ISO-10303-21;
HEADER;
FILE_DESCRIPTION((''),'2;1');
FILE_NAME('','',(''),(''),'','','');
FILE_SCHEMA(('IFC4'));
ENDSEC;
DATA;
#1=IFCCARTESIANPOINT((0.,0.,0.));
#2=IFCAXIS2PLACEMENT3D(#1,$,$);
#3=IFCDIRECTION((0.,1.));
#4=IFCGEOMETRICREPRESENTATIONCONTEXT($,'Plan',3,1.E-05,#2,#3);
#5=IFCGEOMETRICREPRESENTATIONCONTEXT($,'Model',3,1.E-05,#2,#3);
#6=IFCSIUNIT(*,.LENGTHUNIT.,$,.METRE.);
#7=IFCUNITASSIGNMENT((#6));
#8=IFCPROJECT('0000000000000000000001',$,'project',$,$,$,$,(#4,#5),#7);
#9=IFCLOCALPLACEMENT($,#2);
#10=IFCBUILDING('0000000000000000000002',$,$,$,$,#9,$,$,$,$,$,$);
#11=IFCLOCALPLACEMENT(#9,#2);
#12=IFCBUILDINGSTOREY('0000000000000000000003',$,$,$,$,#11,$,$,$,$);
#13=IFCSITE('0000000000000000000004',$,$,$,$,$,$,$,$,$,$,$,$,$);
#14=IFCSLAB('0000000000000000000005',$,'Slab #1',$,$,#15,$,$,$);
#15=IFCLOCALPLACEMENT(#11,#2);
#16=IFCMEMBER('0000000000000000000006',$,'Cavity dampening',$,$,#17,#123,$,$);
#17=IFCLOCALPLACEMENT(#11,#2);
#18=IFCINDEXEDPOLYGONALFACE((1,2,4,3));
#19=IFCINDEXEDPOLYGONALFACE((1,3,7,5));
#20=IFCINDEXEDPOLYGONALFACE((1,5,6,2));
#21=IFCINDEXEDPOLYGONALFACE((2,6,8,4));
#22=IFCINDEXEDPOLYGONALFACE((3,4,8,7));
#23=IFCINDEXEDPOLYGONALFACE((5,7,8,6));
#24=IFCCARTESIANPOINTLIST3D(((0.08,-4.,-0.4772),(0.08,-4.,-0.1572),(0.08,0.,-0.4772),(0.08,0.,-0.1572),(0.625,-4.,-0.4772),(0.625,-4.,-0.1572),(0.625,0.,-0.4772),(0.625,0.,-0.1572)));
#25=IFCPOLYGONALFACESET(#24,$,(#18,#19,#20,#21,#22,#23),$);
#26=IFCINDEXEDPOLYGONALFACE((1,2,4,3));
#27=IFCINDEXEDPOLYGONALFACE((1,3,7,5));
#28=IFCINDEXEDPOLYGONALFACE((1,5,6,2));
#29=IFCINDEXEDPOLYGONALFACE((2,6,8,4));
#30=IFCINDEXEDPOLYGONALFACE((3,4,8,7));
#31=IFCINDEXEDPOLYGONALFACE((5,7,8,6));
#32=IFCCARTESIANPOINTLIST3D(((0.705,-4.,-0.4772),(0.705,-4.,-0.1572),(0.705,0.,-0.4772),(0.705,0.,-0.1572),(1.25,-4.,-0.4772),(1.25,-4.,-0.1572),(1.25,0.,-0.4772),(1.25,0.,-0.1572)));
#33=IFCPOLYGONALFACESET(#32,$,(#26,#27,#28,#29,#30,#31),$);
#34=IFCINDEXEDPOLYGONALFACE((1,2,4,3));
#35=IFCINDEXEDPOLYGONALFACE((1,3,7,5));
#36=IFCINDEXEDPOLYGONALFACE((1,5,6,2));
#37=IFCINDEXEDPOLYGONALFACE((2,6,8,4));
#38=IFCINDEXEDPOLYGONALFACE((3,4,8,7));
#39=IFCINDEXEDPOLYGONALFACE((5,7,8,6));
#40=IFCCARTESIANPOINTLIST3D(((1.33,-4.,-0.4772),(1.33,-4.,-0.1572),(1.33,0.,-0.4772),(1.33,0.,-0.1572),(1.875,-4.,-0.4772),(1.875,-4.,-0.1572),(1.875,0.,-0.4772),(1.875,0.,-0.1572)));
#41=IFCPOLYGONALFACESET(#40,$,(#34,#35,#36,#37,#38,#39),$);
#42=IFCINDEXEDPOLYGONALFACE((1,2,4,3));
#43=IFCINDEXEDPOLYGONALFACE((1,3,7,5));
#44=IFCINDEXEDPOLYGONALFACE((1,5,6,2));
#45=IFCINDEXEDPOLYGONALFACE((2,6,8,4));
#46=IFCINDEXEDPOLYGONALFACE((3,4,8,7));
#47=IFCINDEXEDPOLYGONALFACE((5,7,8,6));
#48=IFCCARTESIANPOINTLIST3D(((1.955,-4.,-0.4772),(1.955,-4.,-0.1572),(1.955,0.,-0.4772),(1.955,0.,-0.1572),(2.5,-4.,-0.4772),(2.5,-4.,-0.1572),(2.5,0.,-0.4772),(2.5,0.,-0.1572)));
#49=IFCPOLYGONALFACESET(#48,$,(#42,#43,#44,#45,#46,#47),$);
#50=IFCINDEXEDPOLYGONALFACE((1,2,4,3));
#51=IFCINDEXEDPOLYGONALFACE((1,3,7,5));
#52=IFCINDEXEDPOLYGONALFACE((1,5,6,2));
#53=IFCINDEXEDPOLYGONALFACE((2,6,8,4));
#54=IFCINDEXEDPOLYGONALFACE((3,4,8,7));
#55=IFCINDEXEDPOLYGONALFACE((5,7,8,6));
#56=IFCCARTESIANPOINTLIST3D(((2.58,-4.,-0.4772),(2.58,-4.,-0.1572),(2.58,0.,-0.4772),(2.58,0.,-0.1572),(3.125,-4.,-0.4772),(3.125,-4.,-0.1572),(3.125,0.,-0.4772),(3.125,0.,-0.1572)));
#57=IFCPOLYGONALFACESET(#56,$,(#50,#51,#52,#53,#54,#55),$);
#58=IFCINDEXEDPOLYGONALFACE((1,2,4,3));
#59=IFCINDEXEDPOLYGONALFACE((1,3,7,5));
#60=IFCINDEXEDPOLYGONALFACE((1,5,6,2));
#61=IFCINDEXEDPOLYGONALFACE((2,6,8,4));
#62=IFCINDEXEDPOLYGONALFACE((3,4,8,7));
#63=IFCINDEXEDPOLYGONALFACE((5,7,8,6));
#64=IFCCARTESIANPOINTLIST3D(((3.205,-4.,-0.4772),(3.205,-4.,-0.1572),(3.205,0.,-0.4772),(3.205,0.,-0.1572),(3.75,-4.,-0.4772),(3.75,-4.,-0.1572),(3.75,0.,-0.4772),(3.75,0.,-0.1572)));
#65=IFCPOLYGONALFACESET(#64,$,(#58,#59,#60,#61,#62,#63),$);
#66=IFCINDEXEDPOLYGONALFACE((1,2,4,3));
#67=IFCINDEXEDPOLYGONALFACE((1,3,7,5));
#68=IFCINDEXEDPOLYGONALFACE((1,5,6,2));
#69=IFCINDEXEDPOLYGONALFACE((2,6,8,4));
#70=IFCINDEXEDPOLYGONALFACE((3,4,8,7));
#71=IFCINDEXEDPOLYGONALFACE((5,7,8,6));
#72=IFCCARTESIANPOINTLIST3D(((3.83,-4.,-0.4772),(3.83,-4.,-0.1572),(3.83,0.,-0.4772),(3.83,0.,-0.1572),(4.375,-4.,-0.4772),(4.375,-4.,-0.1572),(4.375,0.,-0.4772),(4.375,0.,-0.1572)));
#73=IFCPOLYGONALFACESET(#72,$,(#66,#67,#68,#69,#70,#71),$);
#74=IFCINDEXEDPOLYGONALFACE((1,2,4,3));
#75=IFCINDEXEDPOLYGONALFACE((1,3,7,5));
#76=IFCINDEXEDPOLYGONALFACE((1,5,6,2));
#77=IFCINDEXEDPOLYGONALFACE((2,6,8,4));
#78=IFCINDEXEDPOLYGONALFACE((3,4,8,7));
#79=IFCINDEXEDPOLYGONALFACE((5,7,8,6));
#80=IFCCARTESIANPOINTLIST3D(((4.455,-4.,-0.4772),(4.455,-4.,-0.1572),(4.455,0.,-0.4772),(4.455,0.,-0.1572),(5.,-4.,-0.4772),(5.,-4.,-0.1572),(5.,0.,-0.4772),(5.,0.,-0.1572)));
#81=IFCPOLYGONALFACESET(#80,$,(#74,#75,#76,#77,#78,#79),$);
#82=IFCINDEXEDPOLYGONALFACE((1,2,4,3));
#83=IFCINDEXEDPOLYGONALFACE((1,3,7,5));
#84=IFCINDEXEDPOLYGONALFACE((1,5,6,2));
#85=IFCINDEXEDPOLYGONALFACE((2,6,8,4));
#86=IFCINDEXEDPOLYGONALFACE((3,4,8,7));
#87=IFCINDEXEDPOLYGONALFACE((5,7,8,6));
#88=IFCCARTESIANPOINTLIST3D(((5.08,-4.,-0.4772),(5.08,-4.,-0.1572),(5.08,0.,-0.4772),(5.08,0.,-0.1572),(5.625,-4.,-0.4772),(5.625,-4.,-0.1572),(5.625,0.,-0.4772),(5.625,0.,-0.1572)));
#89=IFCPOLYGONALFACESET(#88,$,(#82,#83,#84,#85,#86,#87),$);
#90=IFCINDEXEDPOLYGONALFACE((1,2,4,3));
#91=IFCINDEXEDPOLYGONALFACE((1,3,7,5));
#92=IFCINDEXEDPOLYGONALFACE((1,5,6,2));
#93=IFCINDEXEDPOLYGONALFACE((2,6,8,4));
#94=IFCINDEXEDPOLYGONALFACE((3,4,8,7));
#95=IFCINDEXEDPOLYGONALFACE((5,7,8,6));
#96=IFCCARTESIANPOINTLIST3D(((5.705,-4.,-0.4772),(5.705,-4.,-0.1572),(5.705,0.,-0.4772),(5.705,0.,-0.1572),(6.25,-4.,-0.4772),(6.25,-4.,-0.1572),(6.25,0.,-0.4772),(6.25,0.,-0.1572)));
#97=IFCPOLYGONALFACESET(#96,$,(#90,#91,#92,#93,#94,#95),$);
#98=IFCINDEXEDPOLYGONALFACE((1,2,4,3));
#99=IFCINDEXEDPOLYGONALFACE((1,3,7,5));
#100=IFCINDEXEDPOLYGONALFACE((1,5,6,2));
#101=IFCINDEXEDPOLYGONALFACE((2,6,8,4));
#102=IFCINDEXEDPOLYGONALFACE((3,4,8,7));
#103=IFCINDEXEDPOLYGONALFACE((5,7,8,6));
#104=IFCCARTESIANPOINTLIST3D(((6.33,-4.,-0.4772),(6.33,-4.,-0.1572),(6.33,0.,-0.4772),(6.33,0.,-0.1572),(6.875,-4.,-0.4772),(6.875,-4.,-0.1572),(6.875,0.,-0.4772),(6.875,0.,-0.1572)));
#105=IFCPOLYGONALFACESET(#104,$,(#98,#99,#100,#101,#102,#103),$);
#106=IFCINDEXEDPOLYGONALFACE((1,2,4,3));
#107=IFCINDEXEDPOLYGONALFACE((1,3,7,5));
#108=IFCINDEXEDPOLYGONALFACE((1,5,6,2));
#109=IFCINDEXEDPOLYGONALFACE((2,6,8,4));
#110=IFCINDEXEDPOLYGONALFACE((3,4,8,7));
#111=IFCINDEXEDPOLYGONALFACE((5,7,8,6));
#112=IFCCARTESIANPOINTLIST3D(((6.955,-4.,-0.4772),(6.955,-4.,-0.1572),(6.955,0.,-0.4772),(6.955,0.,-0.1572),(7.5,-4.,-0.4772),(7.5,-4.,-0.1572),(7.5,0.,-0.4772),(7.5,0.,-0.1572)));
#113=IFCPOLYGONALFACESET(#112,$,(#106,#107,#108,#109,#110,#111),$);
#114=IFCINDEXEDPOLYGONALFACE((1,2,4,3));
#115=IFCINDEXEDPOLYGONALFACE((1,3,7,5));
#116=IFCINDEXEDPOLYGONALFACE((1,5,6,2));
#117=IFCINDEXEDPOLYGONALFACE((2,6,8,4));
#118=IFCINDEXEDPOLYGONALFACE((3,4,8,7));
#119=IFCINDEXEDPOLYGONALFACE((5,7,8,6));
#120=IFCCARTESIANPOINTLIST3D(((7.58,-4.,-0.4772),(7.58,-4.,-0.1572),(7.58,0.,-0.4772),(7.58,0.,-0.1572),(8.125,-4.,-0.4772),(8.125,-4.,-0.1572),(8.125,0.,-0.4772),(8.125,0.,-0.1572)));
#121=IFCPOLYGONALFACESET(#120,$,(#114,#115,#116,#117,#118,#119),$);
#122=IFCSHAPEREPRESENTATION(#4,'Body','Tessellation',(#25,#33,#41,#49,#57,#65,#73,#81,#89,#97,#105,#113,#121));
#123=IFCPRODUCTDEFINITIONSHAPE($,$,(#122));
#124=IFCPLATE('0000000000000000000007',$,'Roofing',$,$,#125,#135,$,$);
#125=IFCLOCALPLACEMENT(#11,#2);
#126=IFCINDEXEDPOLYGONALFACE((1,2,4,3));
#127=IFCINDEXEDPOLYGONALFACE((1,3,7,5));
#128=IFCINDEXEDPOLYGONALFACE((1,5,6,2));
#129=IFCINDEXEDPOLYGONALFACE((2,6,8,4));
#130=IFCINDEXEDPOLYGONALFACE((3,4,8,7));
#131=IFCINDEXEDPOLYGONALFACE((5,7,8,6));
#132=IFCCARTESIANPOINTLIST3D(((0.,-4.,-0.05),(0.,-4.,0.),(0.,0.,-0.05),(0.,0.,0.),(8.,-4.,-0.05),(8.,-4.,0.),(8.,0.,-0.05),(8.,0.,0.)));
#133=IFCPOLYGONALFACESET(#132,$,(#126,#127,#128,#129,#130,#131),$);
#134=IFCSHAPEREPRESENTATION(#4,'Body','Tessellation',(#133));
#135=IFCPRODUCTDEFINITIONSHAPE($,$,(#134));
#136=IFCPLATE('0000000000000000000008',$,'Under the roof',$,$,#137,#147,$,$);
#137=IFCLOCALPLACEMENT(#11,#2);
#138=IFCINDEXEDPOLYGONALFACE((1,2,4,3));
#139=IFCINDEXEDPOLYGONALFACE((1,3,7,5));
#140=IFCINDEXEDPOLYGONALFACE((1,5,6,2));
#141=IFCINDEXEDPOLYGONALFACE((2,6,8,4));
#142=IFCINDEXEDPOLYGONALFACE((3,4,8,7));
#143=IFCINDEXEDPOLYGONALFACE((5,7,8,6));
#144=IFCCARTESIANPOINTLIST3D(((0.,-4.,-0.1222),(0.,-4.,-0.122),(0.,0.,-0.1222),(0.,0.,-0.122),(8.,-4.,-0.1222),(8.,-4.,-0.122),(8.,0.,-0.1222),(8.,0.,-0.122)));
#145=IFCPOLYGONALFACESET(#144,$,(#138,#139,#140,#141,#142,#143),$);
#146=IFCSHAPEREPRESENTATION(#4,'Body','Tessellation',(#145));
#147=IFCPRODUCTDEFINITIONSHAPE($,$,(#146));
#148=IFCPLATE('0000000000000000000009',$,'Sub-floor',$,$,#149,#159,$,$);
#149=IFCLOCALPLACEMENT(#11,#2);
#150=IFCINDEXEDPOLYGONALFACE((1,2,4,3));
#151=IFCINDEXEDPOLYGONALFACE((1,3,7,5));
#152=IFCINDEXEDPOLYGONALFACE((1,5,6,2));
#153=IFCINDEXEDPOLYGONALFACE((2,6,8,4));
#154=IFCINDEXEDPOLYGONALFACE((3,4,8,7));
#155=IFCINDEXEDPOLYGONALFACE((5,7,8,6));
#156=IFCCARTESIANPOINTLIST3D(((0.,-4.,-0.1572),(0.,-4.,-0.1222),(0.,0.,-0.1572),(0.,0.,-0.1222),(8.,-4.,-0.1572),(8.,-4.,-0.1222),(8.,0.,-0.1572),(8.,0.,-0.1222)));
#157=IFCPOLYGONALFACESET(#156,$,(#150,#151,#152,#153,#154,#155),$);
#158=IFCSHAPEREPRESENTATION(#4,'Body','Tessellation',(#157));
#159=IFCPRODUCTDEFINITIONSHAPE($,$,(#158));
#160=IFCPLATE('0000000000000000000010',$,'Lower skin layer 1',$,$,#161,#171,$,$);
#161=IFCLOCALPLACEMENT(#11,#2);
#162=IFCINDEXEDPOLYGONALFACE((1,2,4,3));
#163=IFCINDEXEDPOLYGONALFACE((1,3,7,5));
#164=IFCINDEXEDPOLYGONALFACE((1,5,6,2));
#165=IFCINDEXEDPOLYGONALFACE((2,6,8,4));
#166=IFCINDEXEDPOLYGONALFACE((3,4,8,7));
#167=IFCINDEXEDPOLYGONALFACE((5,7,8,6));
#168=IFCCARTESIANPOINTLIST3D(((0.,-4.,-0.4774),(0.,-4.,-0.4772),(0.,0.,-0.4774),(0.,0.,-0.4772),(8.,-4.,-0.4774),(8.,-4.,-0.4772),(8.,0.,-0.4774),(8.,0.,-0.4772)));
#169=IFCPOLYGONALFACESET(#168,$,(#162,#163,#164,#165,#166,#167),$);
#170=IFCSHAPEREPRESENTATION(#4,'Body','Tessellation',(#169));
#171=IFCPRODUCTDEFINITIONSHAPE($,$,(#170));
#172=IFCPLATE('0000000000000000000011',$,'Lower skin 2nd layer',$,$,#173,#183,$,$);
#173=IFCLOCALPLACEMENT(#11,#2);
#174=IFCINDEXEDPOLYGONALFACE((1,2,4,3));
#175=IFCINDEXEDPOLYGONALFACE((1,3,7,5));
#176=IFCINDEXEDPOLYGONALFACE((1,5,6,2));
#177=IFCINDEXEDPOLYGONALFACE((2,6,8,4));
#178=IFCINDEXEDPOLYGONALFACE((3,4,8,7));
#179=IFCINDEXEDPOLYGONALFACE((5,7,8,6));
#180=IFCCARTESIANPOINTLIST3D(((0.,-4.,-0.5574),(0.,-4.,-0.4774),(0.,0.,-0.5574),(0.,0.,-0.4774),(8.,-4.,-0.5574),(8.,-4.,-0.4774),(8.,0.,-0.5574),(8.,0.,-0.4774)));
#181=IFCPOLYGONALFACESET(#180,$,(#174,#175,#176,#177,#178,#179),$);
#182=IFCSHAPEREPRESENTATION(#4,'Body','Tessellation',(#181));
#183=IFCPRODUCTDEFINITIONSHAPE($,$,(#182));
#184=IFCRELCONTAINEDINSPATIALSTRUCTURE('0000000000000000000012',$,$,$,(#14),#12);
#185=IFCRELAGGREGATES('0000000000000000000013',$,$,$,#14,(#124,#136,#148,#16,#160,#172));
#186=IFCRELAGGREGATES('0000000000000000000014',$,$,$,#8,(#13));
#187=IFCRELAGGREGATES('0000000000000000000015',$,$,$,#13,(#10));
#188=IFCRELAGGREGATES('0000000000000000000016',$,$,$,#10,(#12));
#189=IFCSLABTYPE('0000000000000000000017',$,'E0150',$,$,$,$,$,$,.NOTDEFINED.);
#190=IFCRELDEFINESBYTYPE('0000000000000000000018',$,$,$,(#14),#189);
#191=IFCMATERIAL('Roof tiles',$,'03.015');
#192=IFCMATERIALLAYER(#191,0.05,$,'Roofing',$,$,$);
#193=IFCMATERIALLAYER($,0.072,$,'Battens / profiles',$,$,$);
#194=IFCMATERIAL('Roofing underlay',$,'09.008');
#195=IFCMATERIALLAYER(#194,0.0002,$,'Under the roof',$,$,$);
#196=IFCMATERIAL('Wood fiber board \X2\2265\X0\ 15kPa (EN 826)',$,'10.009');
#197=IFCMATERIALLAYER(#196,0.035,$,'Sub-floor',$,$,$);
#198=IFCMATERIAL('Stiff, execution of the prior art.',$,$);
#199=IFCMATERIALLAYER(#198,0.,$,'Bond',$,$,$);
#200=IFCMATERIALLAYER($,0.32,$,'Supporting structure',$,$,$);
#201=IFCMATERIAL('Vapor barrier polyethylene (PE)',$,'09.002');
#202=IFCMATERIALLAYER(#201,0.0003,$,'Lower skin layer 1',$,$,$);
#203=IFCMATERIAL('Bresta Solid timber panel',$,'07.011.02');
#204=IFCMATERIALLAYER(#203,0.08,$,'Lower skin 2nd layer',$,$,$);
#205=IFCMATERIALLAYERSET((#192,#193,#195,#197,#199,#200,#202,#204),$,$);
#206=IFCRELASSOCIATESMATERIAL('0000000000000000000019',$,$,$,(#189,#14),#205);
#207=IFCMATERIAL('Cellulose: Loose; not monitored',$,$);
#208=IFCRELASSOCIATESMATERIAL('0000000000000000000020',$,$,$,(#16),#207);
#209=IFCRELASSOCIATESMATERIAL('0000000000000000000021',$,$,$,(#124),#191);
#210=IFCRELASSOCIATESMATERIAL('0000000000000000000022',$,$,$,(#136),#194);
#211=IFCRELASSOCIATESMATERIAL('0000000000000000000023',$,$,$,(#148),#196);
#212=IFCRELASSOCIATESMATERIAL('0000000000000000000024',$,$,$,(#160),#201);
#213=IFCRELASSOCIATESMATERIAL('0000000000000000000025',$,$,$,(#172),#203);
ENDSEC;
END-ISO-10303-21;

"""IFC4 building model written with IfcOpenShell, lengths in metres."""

from ifc_helpers import new_model, si_unit, direction, frame, frame_2d, origin, origin_with_axes, place, context, project, spatial, rectangle, extrude, material, layer, layer_set, type_object, element, aggregate, save


model = new_model("IFC4")

# Units and contexts
plan_context = context("Plan", 3, precision=1e-05, world=origin(), true_north=direction((0.0, 1.0)))
model_context = context("Model", 3, precision=1e-05, world=origin(), true_north=direction((0.0, 1.0)))
ifc_project = project(units=[si_unit("LENGTHUNIT", "METRE")], contexts=[plan_context, model_context])

# Site, building, storey
site = spatial("IfcSite", under=ifc_project)
building_placement = place(None, origin())
building = spatial("IfcBuilding", under=site, at=building_placement)
storey_placement = place(building_placement, origin())
storey = spatial("IfcBuildingStorey", under=building, at=storey_placement)

# Slab, member, plates
ifc_material_1 = material(Name="Roof tiles", Category="03.015")
ifc_layer_1 = layer(ifc_material_1, 0.05, Name="Roofing")
ifc_layer_2 = layer(None, 0.072, Name="Battens / profiles")
ifc_material_2 = material(Name="Roofing underlay", Category="09.008")
ifc_layer_3 = layer(ifc_material_2, 0.0002, Name="Under the roof")
ifc_material_3 = material(Name="Wood fiber board ≥ 15kPa (EN 826)", Category="10.009")
ifc_layer_4 = layer(ifc_material_3, 0.035, Name="Sub-floor")
ifc_material_4 = material(Name="Stiff, execution of the prior art.")
ifc_layer_5 = layer(ifc_material_4, 0.0, Name="Bond")
ifc_layer_6 = layer(None, 0.32, Name="Supporting structure")
ifc_material_5 = material(Name="Vapor barrier polyethylene (PE)", Category="09.002")
ifc_layer_7 = layer(ifc_material_5, 0.0003, Name="Lower skin layer 1")
ifc_material_6 = material(Name="Bresta Solid timber panel", Category="07.011.02")
ifc_layer_8 = layer(ifc_material_6, 0.08, Name="Lower skin 2nd layer")
ifc_layer_set = layer_set([ifc_layer_1, ifc_layer_2, ifc_layer_3, ifc_layer_4, ifc_layer_5, ifc_layer_6, ifc_layer_7, ifc_layer_8])
slab_type = type_object("IfcSlabType", Name="E0150", PredefinedType="NOTDEFINED", material=ifc_layer_set)
slab_placement = place(None, frame((0.0, 0.0, 0.0), z_axis=(0.0, 0.0, -1.0), x_axis=(1.0, 0.0, 0.0)))
slab = element("IfcSlab", 1, at=slab_placement, inside=storey, type_object=slab_type, material=ifc_layer_set, Name="Slab #1")
ifc_material_7 = material(Name="Cellulose: Loose; not monitored")
member_1_placement = place(slab_placement, origin())
member_1 = element("IfcMember", 2, at=member_1_placement, material=ifc_material_7, Name="Cavity dampening", context=plan_context, shape_type="SweptSolid", body=[
    extrude(rectangle(XDim=0.545, YDim=0.32, at=frame_2d((0.2725, 0.16), x_axis=(1.0, 0.0))), frame((0.08, 4.0, 0.1572), z_axis=(0.0, -1.0, 0.0), x_axis=(1.0, 0.0, 0.0)), (0.0, 0.0, 1.0), 4.0),
    extrude(rectangle(XDim=0.545, YDim=0.32, at=frame_2d((0.2725, 0.16), x_axis=(1.0, 0.0))), frame((0.705, 4.0, 0.1572), z_axis=(0.0, -1.0, 0.0), x_axis=(1.0, 0.0, 0.0)), (0.0, 0.0, 1.0), 4.0),
    extrude(rectangle(XDim=0.545, YDim=0.32, at=frame_2d((0.2725, 0.16), x_axis=(1.0, 0.0))), frame((1.33, 4.0, 0.1572), z_axis=(0.0, -1.0, 0.0), x_axis=(1.0, 0.0, 0.0)), (0.0, 0.0, 1.0), 4.0),
    extrude(rectangle(XDim=0.545, YDim=0.32, at=frame_2d((0.2725, 0.16), x_axis=(1.0, 0.0))), frame((1.955, 4.0, 0.1572), z_axis=(0.0, -1.0, 0.0), x_axis=(1.0, 0.0, 0.0)), (0.0, 0.0, 1.0), 4.0),
    extrude(rectangle(XDim=0.545, YDim=0.32, at=frame_2d((0.2725, 0.16), x_axis=(1.0, 0.0))), frame((2.58, 4.0, 0.1572), z_axis=(0.0, -1.0, 0.0), x_axis=(1.0, 0.0, 0.0)), (0.0, 0.0, 1.0), 4.0),
    extrude(rectangle(XDim=0.545, YDim=0.32, at=frame_2d((0.2725, 0.16), x_axis=(1.0, 0.0))), frame((3.205, 4.0, 0.1572), z_axis=(0.0, -1.0, 0.0), x_axis=(1.0, 0.0, 0.0)), (0.0, 0.0, 1.0), 4.0),
    extrude(rectangle(XDim=0.545, YDim=0.32, at=frame_2d((0.2725, 0.16), x_axis=(1.0, 0.0))), frame((3.83, 4.0, 0.1572), z_axis=(0.0, -1.0, 0.0), x_axis=(1.0, 0.0, 0.0)), (0.0, 0.0, 1.0), 4.0),
    extrude(rectangle(XDim=0.545, YDim=0.32, at=frame_2d((0.2725, 0.16), x_axis=(1.0, 0.0))), frame((4.455, 4.0, 0.1572), z_axis=(0.0, -1.0, 0.0), x_axis=(1.0, 0.0, 0.0)), (0.0, 0.0, 1.0), 4.0),
    extrude(rectangle(XDim=0.545, YDim=0.32, at=frame_2d((0.2725, 0.16), x_axis=(1.0, 0.0))), frame((5.08, 4.0, 0.1572), z_axis=(0.0, -1.0, 0.0), x_axis=(1.0, 0.0, 0.0)), (0.0, 0.0, 1.0), 4.0),
    extrude(rectangle(XDim=0.545, YDim=0.32, at=frame_2d((0.2725, 0.16), x_axis=(1.0, 0.0))), frame((5.705, 4.0, 0.1572), z_axis=(0.0, -1.0, 0.0), x_axis=(1.0, 0.0, 0.0)), (0.0, 0.0, 1.0), 4.0),
    extrude(rectangle(XDim=0.545, YDim=0.32, at=frame_2d((0.2725, 0.16), x_axis=(1.0, 0.0))), frame((6.33, 4.0, 0.1572), z_axis=(0.0, -1.0, 0.0), x_axis=(1.0, 0.0, 0.0)), (0.0, 0.0, 1.0), 4.0),
    extrude(rectangle(XDim=0.545, YDim=0.32, at=frame_2d((0.2725, 0.16), x_axis=(1.0, 0.0))), frame((6.955, 4.0, 0.1572), z_axis=(0.0, -1.0, 0.0), x_axis=(1.0, 0.0, 0.0)), (0.0, 0.0, 1.0), 4.0),
    extrude(rectangle(XDim=0.545, YDim=0.32, at=frame_2d((0.2725, 0.16), x_axis=(1.0, 0.0))), frame((7.58, 4.0, 0.1572), z_axis=(0.0, -1.0, 0.0), x_axis=(1.0, 0.0, 0.0)), (0.0, 0.0, 1.0), 4.0),
])
plate_1_placement = place(slab_placement, origin())
plate_1 = element("IfcPlate", 3, at=plate_1_placement, material=ifc_material_1, Name="Roofing", context=plan_context, shape_type="SweptSolid", body=[
    extrude(rectangle(XDim=8.0, YDim=4.0, at=frame_2d((4.0, 2.0), x_axis=(1.0, 0.0))), origin_with_axes(), (0.0, 0.0, 1.0), 0.05),
])
plate_2_placement = place(slab_placement, origin())
plate_2 = element("IfcPlate", 4, at=plate_2_placement, material=ifc_material_2, Name="Under the roof", context=plan_context, shape_type="SweptSolid", body=[
    extrude(rectangle(XDim=8.0, YDim=4.0, at=frame_2d((4.0, 2.0), x_axis=(1.0, 0.0))), frame((0.0, 0.0, 0.122), z_axis=(0.0, 0.0, 1.0), x_axis=(1.0, 0.0, 0.0)), (0.0, 0.0, 1.0), 0.0002),
])
plate_3_placement = place(slab_placement, origin())
plate_3 = element("IfcPlate", 5, at=plate_3_placement, material=ifc_material_3, Name="Sub-floor", context=plan_context, shape_type="SweptSolid", body=[
    extrude(rectangle(XDim=8.0, YDim=4.0, at=frame_2d((4.0, 2.0), x_axis=(1.0, 0.0))), frame((0.0, 0.0, 0.1222), z_axis=(0.0, 0.0, 1.0), x_axis=(1.0, 0.0, 0.0)), (0.0, 0.0, 1.0), 0.035),
])
plate_4_placement = place(slab_placement, origin())
plate_4 = element("IfcPlate", 6, at=plate_4_placement, material=ifc_material_5, Name="Lower skin layer 1", context=plan_context, shape_type="SweptSolid", body=[
    extrude(rectangle(XDim=8.0, YDim=4.0, at=frame_2d((4.0, 2.0), x_axis=(1.0, 0.0))), frame((0.0, 0.0, 0.4772), z_axis=(0.0, 0.0, 1.0), x_axis=(1.0, 0.0, 0.0)), (0.0, 0.0, 1.0), 0.0003),
])
plate_5_placement = place(slab_placement, origin())
plate_5 = element("IfcPlate", 7, at=plate_5_placement, material=ifc_material_6, Name="Lower skin 2nd layer", context=plan_context, shape_type="SweptSolid", body=[
    extrude(rectangle(XDim=8.0, YDim=4.0, at=frame_2d((4.0, 2.0), x_axis=(1.0, 0.0))), frame((0.0, 0.0, 0.4774), z_axis=(0.0, 0.0, 1.0), x_axis=(1.0, 0.0, 0.0)), (0.0, 0.0, 1.0), 0.08),
])
aggregate(slab, [plate_1, plate_2, plate_3, member_1, plate_4, plate_5])

save(model, "model.ifc")
